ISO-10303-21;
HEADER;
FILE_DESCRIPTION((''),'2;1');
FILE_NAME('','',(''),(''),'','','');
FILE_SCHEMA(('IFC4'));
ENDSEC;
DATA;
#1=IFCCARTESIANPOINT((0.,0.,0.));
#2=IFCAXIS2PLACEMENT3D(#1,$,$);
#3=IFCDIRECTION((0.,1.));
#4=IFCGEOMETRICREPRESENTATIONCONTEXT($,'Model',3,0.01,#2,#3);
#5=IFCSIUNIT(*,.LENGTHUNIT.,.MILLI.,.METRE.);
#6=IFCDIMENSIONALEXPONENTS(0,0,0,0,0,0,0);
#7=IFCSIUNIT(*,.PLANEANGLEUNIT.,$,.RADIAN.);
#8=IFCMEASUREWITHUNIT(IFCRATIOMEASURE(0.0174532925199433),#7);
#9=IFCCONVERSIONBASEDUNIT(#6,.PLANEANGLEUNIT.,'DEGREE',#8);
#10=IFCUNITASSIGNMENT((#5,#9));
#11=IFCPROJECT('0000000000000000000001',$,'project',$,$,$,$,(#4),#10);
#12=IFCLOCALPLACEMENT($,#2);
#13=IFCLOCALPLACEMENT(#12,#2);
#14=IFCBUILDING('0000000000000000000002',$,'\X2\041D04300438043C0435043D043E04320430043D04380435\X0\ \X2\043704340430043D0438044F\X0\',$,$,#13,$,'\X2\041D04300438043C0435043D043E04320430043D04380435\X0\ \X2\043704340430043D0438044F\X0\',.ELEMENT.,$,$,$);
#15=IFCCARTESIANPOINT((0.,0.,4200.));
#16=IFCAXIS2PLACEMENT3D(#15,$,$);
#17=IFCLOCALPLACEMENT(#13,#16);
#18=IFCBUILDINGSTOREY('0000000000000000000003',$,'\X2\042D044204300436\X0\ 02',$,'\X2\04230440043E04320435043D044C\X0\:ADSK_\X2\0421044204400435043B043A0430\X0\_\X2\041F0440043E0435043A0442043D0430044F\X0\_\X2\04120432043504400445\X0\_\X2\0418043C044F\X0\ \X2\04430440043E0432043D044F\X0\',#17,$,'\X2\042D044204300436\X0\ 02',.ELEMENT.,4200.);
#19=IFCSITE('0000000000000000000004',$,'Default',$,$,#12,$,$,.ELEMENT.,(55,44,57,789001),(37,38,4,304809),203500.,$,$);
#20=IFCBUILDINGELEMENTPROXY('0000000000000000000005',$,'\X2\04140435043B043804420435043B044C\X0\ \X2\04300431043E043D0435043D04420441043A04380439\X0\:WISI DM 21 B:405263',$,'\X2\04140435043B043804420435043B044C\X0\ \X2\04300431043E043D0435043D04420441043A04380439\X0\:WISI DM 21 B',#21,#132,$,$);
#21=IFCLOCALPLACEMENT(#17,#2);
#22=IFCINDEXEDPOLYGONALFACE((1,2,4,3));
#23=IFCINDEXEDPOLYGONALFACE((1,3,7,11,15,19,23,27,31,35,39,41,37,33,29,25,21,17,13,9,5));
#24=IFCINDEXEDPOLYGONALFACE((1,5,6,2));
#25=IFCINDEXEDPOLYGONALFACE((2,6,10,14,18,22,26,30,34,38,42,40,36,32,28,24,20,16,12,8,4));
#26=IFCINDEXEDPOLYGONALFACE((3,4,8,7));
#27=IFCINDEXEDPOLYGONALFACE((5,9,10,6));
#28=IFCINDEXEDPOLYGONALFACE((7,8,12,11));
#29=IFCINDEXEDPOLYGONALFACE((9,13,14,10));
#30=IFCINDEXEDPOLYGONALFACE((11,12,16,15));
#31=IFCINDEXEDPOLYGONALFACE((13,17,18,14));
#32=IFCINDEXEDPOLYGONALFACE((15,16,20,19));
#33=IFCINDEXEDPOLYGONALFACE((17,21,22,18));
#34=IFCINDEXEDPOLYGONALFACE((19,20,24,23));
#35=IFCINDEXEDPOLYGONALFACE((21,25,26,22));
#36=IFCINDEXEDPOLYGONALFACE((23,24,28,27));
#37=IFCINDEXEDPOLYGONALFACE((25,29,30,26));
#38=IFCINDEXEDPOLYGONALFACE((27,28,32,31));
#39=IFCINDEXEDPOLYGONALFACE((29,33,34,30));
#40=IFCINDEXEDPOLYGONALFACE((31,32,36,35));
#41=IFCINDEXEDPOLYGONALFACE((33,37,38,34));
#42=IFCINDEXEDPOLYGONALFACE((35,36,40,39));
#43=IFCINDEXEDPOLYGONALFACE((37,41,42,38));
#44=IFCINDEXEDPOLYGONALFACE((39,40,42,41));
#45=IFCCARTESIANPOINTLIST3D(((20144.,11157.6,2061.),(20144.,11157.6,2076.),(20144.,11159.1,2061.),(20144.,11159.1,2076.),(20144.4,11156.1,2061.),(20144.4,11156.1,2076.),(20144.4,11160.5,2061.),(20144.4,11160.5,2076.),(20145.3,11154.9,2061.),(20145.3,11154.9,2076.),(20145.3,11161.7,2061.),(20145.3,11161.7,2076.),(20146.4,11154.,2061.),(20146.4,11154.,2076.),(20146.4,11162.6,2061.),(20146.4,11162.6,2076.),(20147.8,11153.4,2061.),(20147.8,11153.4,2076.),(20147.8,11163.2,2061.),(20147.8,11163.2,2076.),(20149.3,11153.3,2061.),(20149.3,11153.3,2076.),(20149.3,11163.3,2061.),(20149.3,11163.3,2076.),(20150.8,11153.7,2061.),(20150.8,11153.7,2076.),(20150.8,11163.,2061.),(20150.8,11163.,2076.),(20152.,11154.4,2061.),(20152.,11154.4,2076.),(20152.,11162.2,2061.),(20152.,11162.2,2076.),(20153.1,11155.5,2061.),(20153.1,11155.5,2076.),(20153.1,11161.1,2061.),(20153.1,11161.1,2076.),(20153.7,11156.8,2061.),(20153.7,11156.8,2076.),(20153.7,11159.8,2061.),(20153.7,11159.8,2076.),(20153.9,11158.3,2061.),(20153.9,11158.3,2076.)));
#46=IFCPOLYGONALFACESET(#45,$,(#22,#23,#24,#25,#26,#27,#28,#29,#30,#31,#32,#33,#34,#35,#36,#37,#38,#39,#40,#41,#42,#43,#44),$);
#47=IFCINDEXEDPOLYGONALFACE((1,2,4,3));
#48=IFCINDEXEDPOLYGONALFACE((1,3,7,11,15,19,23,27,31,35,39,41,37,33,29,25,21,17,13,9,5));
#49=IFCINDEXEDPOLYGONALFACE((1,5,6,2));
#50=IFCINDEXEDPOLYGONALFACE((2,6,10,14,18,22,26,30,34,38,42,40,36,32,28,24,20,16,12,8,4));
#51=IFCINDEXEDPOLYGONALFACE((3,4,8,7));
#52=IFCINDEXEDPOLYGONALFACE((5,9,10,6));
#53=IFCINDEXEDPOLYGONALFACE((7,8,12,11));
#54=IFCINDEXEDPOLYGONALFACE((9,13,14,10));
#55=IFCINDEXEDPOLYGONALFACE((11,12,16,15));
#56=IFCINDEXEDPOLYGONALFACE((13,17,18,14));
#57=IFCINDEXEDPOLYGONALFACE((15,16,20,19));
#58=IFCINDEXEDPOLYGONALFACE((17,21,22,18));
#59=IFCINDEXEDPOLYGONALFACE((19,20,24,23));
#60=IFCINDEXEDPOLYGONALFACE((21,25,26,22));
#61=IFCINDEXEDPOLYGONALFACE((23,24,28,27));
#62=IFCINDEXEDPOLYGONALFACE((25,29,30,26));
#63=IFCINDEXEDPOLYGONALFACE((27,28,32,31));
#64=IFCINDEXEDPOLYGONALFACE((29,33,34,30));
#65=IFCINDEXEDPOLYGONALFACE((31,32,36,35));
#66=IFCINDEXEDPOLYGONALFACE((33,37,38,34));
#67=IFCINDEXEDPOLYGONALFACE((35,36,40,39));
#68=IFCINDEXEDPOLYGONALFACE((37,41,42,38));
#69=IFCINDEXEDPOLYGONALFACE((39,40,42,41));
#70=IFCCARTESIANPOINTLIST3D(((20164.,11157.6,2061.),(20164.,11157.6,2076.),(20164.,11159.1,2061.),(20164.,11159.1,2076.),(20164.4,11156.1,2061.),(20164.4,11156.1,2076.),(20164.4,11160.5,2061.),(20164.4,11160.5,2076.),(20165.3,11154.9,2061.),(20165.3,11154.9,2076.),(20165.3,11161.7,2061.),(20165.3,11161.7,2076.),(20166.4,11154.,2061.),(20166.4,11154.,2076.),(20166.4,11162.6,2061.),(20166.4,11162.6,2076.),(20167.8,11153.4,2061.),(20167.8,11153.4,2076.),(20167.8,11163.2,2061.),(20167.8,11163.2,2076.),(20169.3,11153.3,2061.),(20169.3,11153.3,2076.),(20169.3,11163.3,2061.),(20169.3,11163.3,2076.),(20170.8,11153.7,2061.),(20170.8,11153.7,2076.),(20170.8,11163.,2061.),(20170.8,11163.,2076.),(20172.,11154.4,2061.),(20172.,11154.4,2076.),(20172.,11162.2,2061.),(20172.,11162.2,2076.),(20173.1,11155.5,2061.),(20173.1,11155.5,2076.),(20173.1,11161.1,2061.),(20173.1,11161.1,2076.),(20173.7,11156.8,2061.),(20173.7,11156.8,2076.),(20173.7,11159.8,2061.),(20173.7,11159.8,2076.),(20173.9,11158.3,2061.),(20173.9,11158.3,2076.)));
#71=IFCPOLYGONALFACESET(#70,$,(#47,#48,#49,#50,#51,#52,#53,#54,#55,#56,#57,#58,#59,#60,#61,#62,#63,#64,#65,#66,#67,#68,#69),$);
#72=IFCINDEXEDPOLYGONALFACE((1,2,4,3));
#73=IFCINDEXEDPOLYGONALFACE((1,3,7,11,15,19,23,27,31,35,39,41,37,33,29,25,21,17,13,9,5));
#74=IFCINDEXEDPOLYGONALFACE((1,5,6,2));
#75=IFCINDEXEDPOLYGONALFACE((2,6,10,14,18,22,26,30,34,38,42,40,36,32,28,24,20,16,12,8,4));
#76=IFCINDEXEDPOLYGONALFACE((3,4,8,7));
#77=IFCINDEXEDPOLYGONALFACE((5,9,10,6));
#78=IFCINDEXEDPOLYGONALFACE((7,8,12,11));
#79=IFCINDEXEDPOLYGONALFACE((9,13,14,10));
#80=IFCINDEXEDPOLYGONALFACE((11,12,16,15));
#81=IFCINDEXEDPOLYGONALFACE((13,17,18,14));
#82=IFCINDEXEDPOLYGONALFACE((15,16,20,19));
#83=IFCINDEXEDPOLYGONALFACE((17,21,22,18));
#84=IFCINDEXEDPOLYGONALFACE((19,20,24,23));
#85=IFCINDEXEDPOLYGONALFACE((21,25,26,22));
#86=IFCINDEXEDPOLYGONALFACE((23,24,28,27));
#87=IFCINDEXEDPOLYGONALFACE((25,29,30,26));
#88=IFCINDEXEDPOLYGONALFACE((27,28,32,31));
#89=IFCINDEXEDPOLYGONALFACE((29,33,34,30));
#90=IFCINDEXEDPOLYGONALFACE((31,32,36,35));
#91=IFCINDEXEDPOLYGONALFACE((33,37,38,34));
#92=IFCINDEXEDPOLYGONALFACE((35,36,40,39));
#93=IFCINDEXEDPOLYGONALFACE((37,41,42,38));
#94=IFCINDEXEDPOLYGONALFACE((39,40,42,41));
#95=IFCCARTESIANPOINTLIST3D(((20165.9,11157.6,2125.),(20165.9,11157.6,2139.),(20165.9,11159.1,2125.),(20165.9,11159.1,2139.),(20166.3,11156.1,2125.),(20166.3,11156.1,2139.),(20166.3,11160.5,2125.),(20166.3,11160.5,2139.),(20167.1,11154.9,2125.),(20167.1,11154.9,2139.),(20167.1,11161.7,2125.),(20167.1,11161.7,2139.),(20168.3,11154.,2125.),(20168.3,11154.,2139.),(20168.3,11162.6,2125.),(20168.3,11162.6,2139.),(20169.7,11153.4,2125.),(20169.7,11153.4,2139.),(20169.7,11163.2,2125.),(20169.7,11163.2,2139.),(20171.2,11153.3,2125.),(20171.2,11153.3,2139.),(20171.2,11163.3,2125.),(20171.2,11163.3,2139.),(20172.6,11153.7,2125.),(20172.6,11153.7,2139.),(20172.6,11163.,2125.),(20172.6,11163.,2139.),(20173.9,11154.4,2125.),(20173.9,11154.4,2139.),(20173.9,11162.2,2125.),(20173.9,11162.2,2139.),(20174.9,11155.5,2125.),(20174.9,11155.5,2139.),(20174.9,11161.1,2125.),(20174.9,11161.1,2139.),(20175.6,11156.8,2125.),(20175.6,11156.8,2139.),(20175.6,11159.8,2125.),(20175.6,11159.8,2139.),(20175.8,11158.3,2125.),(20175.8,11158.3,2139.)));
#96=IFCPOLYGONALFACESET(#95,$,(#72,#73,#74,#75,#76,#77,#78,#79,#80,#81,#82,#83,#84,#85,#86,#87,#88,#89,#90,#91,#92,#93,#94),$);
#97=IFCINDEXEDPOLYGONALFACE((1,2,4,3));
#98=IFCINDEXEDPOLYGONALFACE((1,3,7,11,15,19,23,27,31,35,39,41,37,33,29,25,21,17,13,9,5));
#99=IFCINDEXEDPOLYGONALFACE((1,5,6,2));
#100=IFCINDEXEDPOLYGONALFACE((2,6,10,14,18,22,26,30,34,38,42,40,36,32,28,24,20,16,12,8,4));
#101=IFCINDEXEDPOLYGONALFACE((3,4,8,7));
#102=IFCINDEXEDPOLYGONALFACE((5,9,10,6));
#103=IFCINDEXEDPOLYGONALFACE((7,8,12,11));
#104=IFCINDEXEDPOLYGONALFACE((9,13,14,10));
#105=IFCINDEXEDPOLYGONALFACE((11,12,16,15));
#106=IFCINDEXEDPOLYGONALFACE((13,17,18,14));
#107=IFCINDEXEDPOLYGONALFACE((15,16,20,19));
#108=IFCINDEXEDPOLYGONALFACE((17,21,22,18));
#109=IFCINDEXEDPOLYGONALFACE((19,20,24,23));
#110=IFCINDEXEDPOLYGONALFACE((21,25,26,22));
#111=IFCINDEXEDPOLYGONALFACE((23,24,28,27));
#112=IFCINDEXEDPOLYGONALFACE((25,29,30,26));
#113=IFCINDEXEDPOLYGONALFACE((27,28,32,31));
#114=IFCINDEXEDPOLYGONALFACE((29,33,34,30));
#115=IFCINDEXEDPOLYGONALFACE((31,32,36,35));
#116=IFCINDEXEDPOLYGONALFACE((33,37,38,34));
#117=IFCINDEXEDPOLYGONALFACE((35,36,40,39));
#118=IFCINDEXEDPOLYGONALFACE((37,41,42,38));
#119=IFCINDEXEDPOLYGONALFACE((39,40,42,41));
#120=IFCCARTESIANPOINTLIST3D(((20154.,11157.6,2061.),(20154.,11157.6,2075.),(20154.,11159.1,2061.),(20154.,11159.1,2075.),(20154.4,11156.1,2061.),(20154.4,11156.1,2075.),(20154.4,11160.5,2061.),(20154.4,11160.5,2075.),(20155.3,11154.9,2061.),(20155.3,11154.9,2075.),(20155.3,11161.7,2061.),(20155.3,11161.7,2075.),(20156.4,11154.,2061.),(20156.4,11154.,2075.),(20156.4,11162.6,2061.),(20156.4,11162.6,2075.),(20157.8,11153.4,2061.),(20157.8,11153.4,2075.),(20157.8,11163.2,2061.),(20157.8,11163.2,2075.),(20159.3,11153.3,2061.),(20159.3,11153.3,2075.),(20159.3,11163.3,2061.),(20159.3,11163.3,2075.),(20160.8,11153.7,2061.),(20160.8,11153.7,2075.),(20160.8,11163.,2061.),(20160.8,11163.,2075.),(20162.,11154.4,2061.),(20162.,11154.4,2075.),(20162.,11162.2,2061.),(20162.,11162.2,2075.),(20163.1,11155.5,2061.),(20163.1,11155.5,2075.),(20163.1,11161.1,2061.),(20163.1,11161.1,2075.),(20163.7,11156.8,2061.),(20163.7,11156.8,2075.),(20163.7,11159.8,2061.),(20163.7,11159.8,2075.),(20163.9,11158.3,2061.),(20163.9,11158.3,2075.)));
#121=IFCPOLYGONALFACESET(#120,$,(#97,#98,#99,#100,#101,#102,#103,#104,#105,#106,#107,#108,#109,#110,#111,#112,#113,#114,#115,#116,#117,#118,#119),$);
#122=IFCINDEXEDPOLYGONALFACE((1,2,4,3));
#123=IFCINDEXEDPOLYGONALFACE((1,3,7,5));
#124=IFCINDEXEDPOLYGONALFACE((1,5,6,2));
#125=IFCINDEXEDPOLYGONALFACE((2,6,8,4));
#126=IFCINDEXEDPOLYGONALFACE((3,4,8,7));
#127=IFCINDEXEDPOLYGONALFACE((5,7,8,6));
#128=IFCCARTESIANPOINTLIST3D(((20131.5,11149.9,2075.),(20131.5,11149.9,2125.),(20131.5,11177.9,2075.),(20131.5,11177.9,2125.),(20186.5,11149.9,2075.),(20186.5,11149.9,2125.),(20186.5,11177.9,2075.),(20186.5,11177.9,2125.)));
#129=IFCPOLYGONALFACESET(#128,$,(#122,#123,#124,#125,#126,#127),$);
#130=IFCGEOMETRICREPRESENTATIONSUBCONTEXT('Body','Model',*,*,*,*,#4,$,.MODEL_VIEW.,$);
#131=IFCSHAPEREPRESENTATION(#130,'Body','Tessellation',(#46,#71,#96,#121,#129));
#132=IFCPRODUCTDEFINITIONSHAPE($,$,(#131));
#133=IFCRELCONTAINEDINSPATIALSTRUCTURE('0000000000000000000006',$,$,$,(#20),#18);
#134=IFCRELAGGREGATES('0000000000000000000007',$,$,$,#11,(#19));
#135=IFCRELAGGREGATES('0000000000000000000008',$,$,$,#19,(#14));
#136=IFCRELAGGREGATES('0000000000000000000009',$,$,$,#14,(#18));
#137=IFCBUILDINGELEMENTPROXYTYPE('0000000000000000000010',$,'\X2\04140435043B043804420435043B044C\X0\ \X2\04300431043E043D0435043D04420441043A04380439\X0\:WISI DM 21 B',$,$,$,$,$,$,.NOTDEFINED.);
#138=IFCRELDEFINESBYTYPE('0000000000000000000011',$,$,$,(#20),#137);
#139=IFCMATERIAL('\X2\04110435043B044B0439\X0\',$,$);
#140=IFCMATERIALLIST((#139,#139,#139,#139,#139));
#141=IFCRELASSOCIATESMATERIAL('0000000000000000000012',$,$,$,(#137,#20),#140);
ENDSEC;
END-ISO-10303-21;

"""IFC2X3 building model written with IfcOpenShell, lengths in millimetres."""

from ifc_helpers import new_model, entity, si_unit, converted_unit, direction, frame, origin, origin_2d_with_axis, place, context, subcontext, project, spatial, rectangle, circle, extrude, source, transform, mapped, material, material_list, type_object, type_shapes, element, save


model = new_model("IFC2X3")

# Units and contexts
model_context = context("Model", 3, precision=0.01, world=origin(), true_north=direction((0.0, 1.0)))
body_context = subcontext(model_context, "Body", "Model", "MODEL_VIEW")
ifc_project = project(units=[si_unit("LENGTHUNIT", "METRE", prefix="MILLI"), converted_unit("PLANEANGLEUNIT", "DEGREE", entity("IfcRatioMeasure", 0.0174532925199433), si_unit("PLANEANGLEUNIT", "RADIAN"), dimensions=[0, 0, 0, 0, 0, 0, 0])], contexts=[model_context])

# Site, building, storey
site_placement = place(None, origin())
site = spatial("IfcSite", under=ifc_project, at=site_placement, Name="Default", CompositionType="ELEMENT", RefLatitude=(55, 44, 57, 789001), RefLongitude=(37, 38, 4, 304809), RefElevation=203500.0)
building_placement = place(site_placement, origin())
building = spatial("IfcBuilding", under=site, at=building_placement, Name="Наименование здания", LongName="Наименование здания", CompositionType="ELEMENT")
storey_placement = place(building_placement, frame((0.0, 0.0, 4200.0)))
storey = spatial("IfcBuildingStorey", under=building, at=storey_placement, Name="Этаж 02", ObjectType="Уровень:ADSK_Стрелка_Проектная_Вверх_Имя уровня", LongName="Этаж 02", CompositionType="ELEMENT", Elevation=4200.0)

# Building element proxy
ifc_material_1 = material(Name="Белый")
ifc_material_list_1 = material_list([ifc_material_1, ifc_material_1, ifc_material_1, ifc_material_1, ifc_material_1])
building_element_proxy_type_1 = type_object("IfcBuildingElementProxyType", Name="Делитель абонентский:WISI DM 21 B", PredefinedType="NOTDEFINED", material=ifc_material_list_1)
shared_shape_1 = source(origin(), body_context, "Body", "SweptSolid", [
    extrude(circle(Radius=5.0, at=origin_2d_with_axis()), frame((10.0, -39.0, 8.4), z_axis=(0.0, 1.0, 0.0), x_axis=(-1.0, 0.0, 0.0)), (0.0, 0.0, 1.0), 15.0),
    extrude(circle(Radius=5.0, at=origin_2d_with_axis()), frame((-10.0, -39.0, 8.4), z_axis=(0.0, 1.0, 0.0), x_axis=(-1.0, 0.0, 0.0)), (0.0, 0.0, 1.0), 15.0),
    extrude(circle(Radius=5.0, at=origin_2d_with_axis()), frame((-11.8, 25.0, 8.4), z_axis=(0.0, 1.0, 0.0), x_axis=(-1.0, 0.0, 0.0)), (0.0, 0.0, 1.0), 14.0),
    extrude(circle(Radius=5.0, at=origin_2d_with_axis()), frame((0.0, -39.0, 8.4), z_axis=(0.0, 1.0, 0.0), x_axis=(-1.0, 0.0, 0.0)), (0.0, 0.0, 1.0), 14.0),
    extrude(rectangle(XDim=55.0, YDim=50.0, at=origin_2d_with_axis()), frame((0.0, 0.0, 0.0), z_axis=(0.0, 0.0, 1.0), x_axis=(-1.0, 0.0, 0.0)), (0.0, 0.0, 1.0), 28.0),
])
type_shapes(building_element_proxy_type_1, [shared_shape_1])
proxy_1_placement = place(storey_placement, frame((20159.0, 11149.9, 2100.0), z_axis=(0.0, 1.0, 0.0), x_axis=(-1.0, 0.0, 0.0)))
element("IfcBuildingElementProxy", 1, at=proxy_1_placement, inside=storey, type_object=building_element_proxy_type_1, material=ifc_material_list_1, Name="Делитель абонентский:WISI DM 21 B:405263", ObjectType="Делитель абонентский:WISI DM 21 B", context=body_context, shape_type="MappedRepresentation", body=[
    mapped(shared_shape_1, transform((0.0, 0.0, 0.0), scale=1.0)),
])

save(model, "model.ifc")
